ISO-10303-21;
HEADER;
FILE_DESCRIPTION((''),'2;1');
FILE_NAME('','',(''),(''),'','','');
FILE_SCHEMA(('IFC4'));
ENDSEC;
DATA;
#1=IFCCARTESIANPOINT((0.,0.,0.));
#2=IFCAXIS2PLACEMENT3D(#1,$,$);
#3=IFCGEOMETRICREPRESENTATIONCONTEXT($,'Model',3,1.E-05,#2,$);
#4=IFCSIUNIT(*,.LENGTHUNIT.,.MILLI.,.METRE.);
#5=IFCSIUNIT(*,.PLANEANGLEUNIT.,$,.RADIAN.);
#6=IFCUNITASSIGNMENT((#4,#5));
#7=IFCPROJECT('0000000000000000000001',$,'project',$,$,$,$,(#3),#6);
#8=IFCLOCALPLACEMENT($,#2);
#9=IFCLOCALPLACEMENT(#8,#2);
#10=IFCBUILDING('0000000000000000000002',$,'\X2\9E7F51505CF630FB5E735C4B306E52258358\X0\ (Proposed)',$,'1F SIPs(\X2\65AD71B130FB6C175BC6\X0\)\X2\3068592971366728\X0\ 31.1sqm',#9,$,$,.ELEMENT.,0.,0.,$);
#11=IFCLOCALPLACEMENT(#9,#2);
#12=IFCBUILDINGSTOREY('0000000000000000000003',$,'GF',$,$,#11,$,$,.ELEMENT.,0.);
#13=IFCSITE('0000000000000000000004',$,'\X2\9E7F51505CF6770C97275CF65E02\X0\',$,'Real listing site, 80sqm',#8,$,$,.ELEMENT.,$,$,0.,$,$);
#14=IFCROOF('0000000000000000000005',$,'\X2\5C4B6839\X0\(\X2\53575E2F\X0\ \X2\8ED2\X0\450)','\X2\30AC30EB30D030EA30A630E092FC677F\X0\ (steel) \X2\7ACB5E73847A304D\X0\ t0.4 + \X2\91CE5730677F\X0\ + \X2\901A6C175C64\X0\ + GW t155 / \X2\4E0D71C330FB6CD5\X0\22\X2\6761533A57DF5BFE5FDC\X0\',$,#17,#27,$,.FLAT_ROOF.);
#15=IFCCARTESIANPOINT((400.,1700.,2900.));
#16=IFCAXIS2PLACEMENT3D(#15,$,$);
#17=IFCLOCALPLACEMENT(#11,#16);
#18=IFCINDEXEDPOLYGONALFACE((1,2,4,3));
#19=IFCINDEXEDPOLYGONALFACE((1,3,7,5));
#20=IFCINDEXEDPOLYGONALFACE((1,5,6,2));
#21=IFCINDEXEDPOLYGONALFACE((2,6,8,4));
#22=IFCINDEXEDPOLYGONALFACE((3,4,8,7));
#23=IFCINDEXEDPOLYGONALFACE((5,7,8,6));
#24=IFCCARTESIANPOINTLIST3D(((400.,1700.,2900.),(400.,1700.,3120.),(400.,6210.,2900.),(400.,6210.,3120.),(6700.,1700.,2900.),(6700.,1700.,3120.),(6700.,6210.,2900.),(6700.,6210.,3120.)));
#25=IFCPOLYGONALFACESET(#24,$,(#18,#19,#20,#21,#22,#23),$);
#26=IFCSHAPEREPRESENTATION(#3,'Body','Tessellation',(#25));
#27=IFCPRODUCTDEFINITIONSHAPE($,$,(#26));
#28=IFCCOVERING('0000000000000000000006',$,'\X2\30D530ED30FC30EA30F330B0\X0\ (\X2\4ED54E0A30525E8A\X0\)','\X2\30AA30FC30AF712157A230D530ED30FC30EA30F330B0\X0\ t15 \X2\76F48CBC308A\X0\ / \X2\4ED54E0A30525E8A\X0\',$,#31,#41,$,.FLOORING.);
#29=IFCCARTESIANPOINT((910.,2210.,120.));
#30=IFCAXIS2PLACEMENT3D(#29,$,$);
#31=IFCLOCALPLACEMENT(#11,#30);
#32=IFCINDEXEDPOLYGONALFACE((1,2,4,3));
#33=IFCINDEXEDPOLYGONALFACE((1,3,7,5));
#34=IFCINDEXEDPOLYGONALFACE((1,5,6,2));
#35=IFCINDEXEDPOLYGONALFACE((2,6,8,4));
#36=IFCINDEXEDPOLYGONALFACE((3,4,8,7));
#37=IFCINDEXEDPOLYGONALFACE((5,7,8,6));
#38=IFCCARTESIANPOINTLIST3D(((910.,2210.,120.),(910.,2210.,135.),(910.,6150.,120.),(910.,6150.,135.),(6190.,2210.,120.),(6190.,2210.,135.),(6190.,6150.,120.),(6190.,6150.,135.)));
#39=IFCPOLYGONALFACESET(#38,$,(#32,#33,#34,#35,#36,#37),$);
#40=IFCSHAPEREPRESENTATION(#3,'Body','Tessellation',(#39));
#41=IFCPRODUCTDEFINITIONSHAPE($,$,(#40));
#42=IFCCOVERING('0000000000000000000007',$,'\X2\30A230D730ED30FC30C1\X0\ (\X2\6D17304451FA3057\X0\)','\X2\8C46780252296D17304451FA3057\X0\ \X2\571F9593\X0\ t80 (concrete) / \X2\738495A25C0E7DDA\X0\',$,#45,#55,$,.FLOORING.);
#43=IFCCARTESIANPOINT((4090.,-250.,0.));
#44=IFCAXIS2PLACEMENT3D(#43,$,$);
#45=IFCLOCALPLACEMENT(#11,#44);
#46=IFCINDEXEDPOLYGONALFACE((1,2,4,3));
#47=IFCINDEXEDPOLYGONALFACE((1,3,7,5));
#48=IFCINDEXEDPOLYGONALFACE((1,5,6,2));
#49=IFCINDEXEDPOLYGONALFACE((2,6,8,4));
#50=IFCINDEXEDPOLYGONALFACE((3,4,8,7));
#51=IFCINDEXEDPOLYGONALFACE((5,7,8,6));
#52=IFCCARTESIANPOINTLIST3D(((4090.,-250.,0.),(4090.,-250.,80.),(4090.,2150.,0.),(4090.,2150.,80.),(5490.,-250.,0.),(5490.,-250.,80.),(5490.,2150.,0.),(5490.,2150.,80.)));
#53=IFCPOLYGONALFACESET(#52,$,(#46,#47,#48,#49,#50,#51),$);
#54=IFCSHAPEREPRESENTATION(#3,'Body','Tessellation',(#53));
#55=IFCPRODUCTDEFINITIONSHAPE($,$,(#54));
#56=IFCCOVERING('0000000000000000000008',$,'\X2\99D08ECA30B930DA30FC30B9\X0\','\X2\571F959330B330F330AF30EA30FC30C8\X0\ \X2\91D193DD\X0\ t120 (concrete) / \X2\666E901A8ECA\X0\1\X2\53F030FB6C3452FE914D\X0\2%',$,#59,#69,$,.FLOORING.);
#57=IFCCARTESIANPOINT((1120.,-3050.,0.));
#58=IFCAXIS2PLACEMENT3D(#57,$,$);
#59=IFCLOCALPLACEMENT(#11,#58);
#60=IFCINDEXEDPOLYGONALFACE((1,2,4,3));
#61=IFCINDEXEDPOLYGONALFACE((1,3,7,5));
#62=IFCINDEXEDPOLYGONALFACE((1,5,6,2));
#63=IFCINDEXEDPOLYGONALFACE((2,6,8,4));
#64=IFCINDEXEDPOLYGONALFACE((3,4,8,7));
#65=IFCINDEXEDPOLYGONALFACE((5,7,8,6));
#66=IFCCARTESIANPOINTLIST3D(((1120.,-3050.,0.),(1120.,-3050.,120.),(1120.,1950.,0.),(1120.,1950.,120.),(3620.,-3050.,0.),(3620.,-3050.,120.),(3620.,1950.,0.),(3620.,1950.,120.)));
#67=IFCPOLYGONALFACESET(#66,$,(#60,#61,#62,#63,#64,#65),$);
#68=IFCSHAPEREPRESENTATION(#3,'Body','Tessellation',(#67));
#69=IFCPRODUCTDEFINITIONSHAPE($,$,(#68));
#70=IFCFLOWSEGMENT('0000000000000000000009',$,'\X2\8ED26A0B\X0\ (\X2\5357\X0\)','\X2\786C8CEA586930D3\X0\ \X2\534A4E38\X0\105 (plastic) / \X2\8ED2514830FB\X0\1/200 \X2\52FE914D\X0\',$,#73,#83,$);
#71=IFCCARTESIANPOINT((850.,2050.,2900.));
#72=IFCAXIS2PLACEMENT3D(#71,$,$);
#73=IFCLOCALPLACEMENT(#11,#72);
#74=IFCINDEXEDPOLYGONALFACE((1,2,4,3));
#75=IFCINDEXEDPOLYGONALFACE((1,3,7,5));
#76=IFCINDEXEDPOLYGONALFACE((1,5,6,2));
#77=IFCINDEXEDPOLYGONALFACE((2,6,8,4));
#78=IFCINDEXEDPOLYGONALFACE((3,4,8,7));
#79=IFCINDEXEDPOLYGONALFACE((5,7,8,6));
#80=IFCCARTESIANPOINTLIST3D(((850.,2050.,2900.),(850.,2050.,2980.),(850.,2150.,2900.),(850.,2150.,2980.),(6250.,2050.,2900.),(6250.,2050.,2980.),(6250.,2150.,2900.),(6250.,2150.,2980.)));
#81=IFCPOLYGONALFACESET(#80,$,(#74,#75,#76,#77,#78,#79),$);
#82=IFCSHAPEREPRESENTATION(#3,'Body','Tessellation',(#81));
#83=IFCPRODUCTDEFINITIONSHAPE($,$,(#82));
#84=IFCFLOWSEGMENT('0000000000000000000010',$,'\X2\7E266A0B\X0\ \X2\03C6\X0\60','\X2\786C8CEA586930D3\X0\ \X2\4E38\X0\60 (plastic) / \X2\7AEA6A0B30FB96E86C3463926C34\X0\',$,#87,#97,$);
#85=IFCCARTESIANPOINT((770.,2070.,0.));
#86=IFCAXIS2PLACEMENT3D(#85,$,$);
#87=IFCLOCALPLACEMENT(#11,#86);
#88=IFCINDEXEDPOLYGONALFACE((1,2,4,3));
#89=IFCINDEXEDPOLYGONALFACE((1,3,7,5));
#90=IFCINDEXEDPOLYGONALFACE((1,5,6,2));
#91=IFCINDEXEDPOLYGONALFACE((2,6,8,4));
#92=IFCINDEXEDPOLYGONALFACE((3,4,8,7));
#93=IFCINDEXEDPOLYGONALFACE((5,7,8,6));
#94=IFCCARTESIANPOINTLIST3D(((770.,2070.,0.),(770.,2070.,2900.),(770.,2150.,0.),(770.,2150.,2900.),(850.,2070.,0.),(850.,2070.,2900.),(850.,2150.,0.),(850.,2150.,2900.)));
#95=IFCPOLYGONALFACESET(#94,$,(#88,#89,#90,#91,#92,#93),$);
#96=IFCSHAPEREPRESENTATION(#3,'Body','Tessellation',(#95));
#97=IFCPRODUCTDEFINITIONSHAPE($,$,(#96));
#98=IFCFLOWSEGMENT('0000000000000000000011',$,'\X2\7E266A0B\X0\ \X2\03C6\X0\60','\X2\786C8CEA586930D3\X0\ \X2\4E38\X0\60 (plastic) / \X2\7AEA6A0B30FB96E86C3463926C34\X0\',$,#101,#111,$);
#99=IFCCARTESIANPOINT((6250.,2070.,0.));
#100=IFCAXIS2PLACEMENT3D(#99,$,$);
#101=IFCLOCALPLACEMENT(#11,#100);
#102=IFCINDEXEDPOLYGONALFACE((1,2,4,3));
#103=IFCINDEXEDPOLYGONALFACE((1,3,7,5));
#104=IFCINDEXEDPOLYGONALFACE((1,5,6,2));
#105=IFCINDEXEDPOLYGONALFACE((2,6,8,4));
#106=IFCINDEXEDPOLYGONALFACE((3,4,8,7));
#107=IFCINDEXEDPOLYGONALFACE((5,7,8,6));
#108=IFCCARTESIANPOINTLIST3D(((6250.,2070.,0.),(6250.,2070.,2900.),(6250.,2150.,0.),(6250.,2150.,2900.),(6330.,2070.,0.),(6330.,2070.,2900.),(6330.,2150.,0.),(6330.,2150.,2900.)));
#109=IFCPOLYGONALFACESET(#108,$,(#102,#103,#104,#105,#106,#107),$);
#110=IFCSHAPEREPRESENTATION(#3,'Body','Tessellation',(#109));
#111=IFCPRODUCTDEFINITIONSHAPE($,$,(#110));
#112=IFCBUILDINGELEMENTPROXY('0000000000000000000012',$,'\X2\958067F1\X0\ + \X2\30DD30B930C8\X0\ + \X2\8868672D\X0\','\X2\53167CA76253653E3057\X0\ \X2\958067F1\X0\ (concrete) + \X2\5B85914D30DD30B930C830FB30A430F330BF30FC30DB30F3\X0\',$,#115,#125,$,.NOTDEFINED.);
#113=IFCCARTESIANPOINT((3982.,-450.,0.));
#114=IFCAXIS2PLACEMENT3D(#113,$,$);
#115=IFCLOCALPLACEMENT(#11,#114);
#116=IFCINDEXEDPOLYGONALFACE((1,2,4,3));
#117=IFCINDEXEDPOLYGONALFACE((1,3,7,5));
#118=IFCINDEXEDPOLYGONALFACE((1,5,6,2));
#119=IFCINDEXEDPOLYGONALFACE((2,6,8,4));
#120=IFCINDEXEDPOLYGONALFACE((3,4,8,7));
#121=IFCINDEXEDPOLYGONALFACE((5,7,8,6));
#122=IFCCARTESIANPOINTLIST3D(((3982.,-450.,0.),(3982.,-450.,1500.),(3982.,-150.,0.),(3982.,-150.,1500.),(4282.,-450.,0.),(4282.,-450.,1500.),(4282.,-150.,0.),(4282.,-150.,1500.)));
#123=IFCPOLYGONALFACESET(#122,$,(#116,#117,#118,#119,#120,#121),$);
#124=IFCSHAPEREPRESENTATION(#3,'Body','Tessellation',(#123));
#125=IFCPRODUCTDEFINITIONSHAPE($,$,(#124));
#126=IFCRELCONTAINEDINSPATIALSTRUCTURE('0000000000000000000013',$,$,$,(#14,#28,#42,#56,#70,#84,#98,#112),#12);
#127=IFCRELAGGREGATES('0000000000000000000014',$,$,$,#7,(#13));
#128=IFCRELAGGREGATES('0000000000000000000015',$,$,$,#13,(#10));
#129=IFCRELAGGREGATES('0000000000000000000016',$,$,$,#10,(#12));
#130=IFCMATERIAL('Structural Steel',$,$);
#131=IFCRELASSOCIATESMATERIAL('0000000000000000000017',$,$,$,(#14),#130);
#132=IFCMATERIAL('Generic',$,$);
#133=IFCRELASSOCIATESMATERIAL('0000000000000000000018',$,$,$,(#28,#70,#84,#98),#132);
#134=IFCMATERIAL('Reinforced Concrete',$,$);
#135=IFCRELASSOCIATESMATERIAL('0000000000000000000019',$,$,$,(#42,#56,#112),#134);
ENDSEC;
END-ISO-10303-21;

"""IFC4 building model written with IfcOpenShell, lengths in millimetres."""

from ifc_helpers import new_model, si_unit, frame, frame_2d, origin, place, context, project, spatial, rectangle, extrude, material, element, save


model = new_model("IFC4")

# Units and contexts
model_context = context("Model", 3, precision=1e-05, world=origin())
ifc_project = project(units=[si_unit("LENGTHUNIT", "METRE", prefix="MILLI"), si_unit("PLANEANGLEUNIT", "RADIAN")], contexts=[model_context])

# Site, building, storey
site_placement = place(None, origin())
site = spatial("IfcSite", under=ifc_project, at=site_placement, Name="鹿児島県霧島市", ObjectType="Real listing site, 80sqm", CompositionType="ELEMENT", RefElevation=0.0)
building_placement = place(site_placement, origin())
building = spatial("IfcBuilding", under=site, at=building_placement, Name="鹿児島・平屋の別荘 (Proposed)", ObjectType="1F SIPs(断熱・気密)と天然木 31.1sqm", CompositionType="ELEMENT", ElevationOfRefHeight=0.0, ElevationOfTerrain=0.0)
storey_placement = place(building_placement, origin())
storey = spatial("IfcBuildingStorey", under=building, at=storey_placement, Name="GF", CompositionType="ELEMENT", Elevation=0.0)

# Shared definitions
ifc_material_1 = material(Name="Reinforced Concrete")

# Roof
ifc_material_2 = material(Name="Structural Steel")
roof_placement = place(storey_placement, frame((400.0, 1700.0, 2900.0)))
element("IfcRoof", 1, at=roof_placement, inside=storey, material=ifc_material_2, Name="屋根(南帯 軒450)", Description="ガルバリウム鋼板 (steel) 立平葺き t0.4 + 野地板 + 通気層 + GW t155 / 不燃・法22条区域対応", PredefinedType="FLAT_ROOF", context=model_context, shape_type="SweptSolid", body=[
    extrude(rectangle(XDim=6300.0, YDim=4510.0, at=frame_2d((3150.0, 2255.0))), frame((400.0, 1700.0, 2900.0)), (0.0, 0.0, 1.0), 220.0),
])

# Coverings
ifc_material_3 = material(Name="Generic")
covering_1_placement = place(storey_placement, frame((910.0, 2210.0, 120.0)))
element("IfcCovering", 2, at=covering_1_placement, inside=storey, material=ifc_material_3, Name="フローリング (仕上げ床)", Description="オーク無垢フローリング t15 直貼り / 仕上げ床", PredefinedType="FLOORING", context=model_context, shape_type="SweptSolid", body=[
    extrude(rectangle(XDim=5280.0, YDim=3940.0, at=frame_2d((2640.0, 1970.0))), frame((910.0, 2210.0, 120.0)), (0.0, 0.0, 1.0), 15.0),
])
covering_2_placement = place(storey_placement, frame((4090.0, -250.0, 0.0)))
element("IfcCovering", 3, at=covering_2_placement, inside=storey, material=ifc_material_1, Name="アプローチ (洗い出し)", Description="豆砂利洗い出し 土間 t80 (concrete) / 玄関導線", PredefinedType="FLOORING", context=model_context, shape_type="SweptSolid", body=[
    extrude(rectangle(XDim=1400.0, YDim=2400.0, at=frame_2d((700.0, 1200.0))), frame((4090.0, -250.0, 0.0)), (0.0, 0.0, 1.0), 80.0),
])
covering_3_placement = place(storey_placement, frame((1120.0, -3050.0, 0.0)))
element("IfcCovering", 4, at=covering_3_placement, inside=storey, material=ifc_material_1, Name="駐車スペース", Description="土間コンクリート 金鏝 t120 (concrete) / 普通車1台・水勾配2%", PredefinedType="FLOORING", context=model_context, shape_type="SweptSolid", body=[
    extrude(rectangle(XDim=2500.0, YDim=5000.0, at=frame_2d((1250.0, 2500.0))), frame((1120.0, -3050.0, 0.0)), (0.0, 0.0, 1.0), 120.0),
])

# Flow segments
flow_segment_1_placement = place(storey_placement, frame((850.0, 2050.0, 2900.0)))
element("IfcFlowSegment", 5, at=flow_segment_1_placement, inside=storey, material=ifc_material_3, Name="軒樋 (南)", Description="硬質塩ビ 半丸105 (plastic) / 軒先・1/200 勾配", context=model_context, shape_type="SweptSolid", body=[
    extrude(rectangle(XDim=5400.0, YDim=100.0, at=frame_2d((2700.0, 50.0))), frame((850.0, 2050.0, 2900.0)), (0.0, 0.0, 1.0), 80.0),
])
flow_segment_2_placement = place(storey_placement, frame((770.0, 2070.0, 0.0)))
element("IfcFlowSegment", 6, at=flow_segment_2_placement, inside=storey, material=ifc_material_3, Name="縦樋 φ60", Description="硬質塩ビ 丸60 (plastic) / 竪樋・雨水排水", context=model_context, shape_type="SweptSolid", body=[
    extrude(rectangle(XDim=80.0, YDim=80.0, at=frame_2d((40.0, 40.0))), frame((770.0, 2070.0, 0.0)), (0.0, 0.0, 1.0), 2900.0),
])
flow_segment_3_placement = place(storey_placement, frame((6250.0, 2070.0, 0.0)))
element("IfcFlowSegment", 7, at=flow_segment_3_placement, inside=storey, material=ifc_material_3, Name="縦樋 φ60", Description="硬質塩ビ 丸60 (plastic) / 竪樋・雨水排水", context=model_context, shape_type="SweptSolid", body=[
    extrude(rectangle(XDim=80.0, YDim=80.0, at=frame_2d((40.0, 40.0))), frame((6250.0, 2070.0, 0.0)), (0.0, 0.0, 1.0), 2900.0),
])

# Building element proxy
proxy_placement = place(storey_placement, frame((3982.0, -450.0, 0.0)))
element("IfcBuildingElementProxy", 8, at=proxy_placement, inside=storey, material=ifc_material_1, Name="門柱 + ポスト + 表札", Description="化粧打放し 門柱 (concrete) + 宅配ポスト・インターホン", PredefinedType="NOTDEFINED", context=model_context, shape_type="SweptSolid", body=[
    extrude(rectangle(XDim=300.0, YDim=300.0, at=frame_2d((150.0, 150.0))), frame((3982.0, -450.0, 0.0)), (0.0, 0.0, 1.0), 1500.0),
])

save(model, "model.ifc")
